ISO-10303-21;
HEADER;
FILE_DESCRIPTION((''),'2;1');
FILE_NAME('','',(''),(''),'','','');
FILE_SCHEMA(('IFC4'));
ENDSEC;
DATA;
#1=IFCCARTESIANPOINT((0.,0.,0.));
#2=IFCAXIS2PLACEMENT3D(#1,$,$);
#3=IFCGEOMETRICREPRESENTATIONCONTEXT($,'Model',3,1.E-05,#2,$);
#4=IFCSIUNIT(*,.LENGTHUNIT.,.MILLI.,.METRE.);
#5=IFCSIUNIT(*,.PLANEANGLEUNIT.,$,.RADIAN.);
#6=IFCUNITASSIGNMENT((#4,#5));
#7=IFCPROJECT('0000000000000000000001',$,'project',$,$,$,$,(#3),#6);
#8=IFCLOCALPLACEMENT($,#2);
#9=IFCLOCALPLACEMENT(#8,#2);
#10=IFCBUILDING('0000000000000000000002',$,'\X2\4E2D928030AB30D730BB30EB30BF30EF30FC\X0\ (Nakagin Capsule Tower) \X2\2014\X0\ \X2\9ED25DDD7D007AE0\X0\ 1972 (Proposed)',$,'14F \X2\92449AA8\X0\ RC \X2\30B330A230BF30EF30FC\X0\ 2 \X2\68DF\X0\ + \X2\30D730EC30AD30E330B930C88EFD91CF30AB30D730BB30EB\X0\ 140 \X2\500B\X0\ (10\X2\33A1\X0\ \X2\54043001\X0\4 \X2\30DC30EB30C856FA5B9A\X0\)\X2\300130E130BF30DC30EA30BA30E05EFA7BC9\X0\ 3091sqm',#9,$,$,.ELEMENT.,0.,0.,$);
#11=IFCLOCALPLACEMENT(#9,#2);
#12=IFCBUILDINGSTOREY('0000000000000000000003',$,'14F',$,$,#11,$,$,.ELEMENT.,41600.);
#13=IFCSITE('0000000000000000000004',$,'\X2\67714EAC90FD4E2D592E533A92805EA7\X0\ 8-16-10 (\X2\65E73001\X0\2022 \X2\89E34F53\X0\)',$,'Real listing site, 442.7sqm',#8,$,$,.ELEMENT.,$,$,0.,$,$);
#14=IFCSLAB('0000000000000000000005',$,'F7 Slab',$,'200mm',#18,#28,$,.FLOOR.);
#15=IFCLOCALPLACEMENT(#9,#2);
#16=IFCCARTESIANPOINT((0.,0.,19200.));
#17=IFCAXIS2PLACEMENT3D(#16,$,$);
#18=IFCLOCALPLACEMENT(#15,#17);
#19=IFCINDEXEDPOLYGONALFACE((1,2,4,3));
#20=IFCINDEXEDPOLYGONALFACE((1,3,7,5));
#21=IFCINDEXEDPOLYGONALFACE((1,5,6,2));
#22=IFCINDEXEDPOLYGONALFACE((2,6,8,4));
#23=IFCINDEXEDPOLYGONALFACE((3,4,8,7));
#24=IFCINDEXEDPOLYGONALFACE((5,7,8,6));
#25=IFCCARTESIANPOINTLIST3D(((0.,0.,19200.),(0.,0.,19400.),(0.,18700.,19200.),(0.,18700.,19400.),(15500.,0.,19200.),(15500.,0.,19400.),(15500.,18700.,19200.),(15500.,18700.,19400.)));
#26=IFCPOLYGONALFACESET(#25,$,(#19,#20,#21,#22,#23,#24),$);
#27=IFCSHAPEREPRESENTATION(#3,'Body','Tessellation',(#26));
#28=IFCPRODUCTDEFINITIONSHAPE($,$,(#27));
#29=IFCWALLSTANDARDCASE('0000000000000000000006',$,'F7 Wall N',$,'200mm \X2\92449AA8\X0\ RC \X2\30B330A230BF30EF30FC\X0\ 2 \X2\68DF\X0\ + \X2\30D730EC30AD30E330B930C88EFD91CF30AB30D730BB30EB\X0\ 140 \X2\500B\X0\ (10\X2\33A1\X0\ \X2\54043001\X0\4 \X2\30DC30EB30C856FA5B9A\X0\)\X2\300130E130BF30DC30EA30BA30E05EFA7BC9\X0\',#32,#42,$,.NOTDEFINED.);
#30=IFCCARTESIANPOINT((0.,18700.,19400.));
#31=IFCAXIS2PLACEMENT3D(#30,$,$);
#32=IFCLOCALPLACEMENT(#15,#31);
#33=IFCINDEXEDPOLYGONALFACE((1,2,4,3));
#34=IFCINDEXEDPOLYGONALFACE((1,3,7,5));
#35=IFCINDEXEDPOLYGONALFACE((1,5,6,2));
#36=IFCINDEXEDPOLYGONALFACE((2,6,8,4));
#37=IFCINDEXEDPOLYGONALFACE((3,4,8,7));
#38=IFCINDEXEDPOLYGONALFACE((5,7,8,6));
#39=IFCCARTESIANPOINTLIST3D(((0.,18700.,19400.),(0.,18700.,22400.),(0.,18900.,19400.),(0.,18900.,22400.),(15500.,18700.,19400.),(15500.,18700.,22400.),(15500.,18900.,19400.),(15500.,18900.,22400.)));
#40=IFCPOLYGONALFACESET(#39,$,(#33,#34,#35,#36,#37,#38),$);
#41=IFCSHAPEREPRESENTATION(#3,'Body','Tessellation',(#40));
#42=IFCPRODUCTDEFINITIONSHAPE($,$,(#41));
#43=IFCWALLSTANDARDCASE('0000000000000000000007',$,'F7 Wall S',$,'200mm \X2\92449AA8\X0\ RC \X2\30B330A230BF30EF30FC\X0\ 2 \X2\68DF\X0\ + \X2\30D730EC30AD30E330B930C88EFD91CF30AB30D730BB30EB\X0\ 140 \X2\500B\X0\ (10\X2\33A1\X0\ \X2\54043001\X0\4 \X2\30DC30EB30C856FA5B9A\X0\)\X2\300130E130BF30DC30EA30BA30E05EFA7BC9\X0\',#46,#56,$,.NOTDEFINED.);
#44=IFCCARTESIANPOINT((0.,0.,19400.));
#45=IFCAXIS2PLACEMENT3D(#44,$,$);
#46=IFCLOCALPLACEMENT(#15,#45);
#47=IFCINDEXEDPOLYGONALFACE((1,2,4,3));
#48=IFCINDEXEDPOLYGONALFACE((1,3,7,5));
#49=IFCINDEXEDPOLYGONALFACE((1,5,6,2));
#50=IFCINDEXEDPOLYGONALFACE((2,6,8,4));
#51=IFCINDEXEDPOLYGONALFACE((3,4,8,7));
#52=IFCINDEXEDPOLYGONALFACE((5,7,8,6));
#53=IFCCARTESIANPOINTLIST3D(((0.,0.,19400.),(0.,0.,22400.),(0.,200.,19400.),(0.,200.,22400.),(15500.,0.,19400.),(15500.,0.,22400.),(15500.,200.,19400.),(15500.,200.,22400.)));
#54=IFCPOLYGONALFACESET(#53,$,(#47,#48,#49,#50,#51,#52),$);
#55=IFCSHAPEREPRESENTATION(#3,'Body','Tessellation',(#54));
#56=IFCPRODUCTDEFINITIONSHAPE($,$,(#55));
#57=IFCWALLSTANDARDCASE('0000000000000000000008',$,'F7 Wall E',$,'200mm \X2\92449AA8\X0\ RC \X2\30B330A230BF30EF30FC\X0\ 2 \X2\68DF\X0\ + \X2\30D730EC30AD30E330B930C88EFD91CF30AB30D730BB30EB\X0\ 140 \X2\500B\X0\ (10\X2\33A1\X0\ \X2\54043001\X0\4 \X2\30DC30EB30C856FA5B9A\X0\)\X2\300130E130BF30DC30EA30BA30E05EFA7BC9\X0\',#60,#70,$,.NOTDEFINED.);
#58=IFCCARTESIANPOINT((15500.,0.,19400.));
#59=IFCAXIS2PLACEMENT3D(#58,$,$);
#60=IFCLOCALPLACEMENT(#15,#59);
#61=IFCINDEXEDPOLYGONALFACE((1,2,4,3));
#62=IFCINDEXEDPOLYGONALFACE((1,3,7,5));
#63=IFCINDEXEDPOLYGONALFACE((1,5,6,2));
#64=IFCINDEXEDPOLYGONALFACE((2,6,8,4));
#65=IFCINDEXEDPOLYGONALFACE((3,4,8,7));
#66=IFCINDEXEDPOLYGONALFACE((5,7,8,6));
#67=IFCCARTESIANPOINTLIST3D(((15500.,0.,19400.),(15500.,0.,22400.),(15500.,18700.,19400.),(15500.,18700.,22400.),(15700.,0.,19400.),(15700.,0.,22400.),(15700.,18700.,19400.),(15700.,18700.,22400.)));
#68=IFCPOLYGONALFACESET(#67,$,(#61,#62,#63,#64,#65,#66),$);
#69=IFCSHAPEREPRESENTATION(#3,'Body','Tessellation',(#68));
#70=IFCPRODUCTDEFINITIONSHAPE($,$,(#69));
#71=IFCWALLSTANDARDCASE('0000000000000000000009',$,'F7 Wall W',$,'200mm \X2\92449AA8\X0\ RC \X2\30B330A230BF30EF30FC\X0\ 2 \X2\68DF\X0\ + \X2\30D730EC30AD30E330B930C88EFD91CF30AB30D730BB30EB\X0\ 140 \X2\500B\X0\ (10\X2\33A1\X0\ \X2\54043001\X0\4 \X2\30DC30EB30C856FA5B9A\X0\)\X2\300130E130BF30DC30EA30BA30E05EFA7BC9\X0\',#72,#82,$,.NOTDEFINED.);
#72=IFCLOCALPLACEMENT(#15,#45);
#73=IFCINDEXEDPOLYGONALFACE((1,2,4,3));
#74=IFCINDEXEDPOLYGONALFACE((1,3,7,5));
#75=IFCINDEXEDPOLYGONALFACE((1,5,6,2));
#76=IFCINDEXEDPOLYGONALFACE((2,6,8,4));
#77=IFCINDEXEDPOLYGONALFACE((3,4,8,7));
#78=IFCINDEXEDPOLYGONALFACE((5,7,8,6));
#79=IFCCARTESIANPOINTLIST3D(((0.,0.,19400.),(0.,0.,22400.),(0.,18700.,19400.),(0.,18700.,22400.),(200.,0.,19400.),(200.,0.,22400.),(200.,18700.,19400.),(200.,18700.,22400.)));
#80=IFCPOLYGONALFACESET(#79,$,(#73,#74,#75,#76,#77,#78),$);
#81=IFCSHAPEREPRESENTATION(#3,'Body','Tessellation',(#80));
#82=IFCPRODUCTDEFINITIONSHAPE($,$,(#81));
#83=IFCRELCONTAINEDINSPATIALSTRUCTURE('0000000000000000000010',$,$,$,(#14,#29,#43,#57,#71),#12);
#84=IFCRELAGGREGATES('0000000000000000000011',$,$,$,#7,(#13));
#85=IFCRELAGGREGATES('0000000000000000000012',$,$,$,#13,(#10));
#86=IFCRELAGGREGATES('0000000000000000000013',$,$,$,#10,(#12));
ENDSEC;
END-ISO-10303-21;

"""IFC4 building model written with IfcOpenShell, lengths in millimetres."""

from ifc_helpers import new_model, si_unit, frame, frame_2d, origin, place, context, project, spatial, rectangle, extrude, element, save


model = new_model("IFC4")

# Units and contexts
model_context = context("Model", 3, precision=1e-05, world=origin())
ifc_project = project(units=[si_unit("LENGTHUNIT", "METRE", prefix="MILLI"), si_unit("PLANEANGLEUNIT", "RADIAN")], contexts=[model_context])

# Site, building, storey
site_placement = place(None, origin())
site = spatial("IfcSite", under=ifc_project, at=site_placement, Name="東京都中央区銀座 8-16-10 (旧、2022 解体)", ObjectType="Real listing site, 442.7sqm", CompositionType="ELEMENT", RefElevation=0.0)
building_placement = place(site_placement, origin())
building = spatial("IfcBuilding", under=site, at=building_placement, Name="中銀カプセルタワー (Nakagin Capsule Tower) — 黒川紀章 1972 (Proposed)", ObjectType="14F 鉄骨 RC コアタワー 2 棟 + プレキャスト軽量カプセル 140 個 (10㎡ 各、4 ボルト固定)、メタボリズム建築 3091sqm", CompositionType="ELEMENT", ElevationOfRefHeight=0.0, ElevationOfTerrain=0.0)
storey_placement = place(building_placement, origin())
storey = spatial("IfcBuildingStorey", under=building, at=storey_placement, Name="14F", CompositionType="ELEMENT", Elevation=41600.0)

# Slab
placement = place(building_placement, origin())
slab_placement = place(placement, frame((0.0, 0.0, 19200.0)))
element("IfcSlab", 1, at=slab_placement, inside=storey, Name="F7 Slab", ObjectType="200mm", PredefinedType="FLOOR", context=model_context, shape_type="SweptSolid", body=[
    extrude(rectangle(XDim=15500.0, YDim=18700.0, at=frame_2d((7750.0, 9350.0))), frame((0.0, 0.0, 19200.0)), (0.0, 0.0, 1.0), 200.0),
])

# Walls
wall_1_placement = place(placement, frame((0.0, 18700.0, 19400.0)))
element("IfcWallStandardCase", 2, at=wall_1_placement, inside=storey, Name="F7 Wall N", ObjectType="200mm 鉄骨 RC コアタワー 2 棟 + プレキャスト軽量カプセル 140 個 (10㎡ 各、4 ボルト固定)、メタボリズム建築", PredefinedType="NOTDEFINED", context=model_context, shape_type="SweptSolid", body=[
    extrude(rectangle(XDim=15500.0, YDim=200.0, at=frame_2d((7750.0, 100.0))), frame((0.0, 18700.0, 19400.0)), (0.0, 0.0, 1.0), 3000.0),
])
wall_2_placement = place(placement, frame((0.0, 0.0, 19400.0)))
element("IfcWallStandardCase", 3, at=wall_2_placement, inside=storey, Name="F7 Wall S", ObjectType="200mm 鉄骨 RC コアタワー 2 棟 + プレキャスト軽量カプセル 140 個 (10㎡ 各、4 ボルト固定)、メタボリズム建築", PredefinedType="NOTDEFINED", context=model_context, shape_type="SweptSolid", body=[
    extrude(rectangle(XDim=15500.0, YDim=200.0, at=frame_2d((7750.0, 100.0))), frame((0.0, 0.0, 19400.0)), (0.0, 0.0, 1.0), 3000.0),
])
wall_3_placement = place(placement, frame((15500.0, 0.0, 19400.0)))
element("IfcWallStandardCase", 4, at=wall_3_placement, inside=storey, Name="F7 Wall E", ObjectType="200mm 鉄骨 RC コアタワー 2 棟 + プレキャスト軽量カプセル 140 個 (10㎡ 各、4 ボルト固定)、メタボリズム建築", PredefinedType="NOTDEFINED", context=model_context, shape_type="SweptSolid", body=[
    extrude(rectangle(XDim=200.0, YDim=18700.0, at=frame_2d((100.0, 9350.0))), frame((15500.0, 0.0, 19400.0)), (0.0, 0.0, 1.0), 3000.0),
])
wall_4_placement = place(placement, frame((0.0, 0.0, 19400.0)))
element("IfcWallStandardCase", 5, at=wall_4_placement, inside=storey, Name="F7 Wall W", ObjectType="200mm 鉄骨 RC コアタワー 2 棟 + プレキャスト軽量カプセル 140 個 (10㎡ 各、4 ボルト固定)、メタボリズム建築", PredefinedType="NOTDEFINED", context=model_context, shape_type="SweptSolid", body=[
    extrude(rectangle(XDim=200.0, YDim=18700.0, at=frame_2d((100.0, 9350.0))), frame((0.0, 0.0, 19400.0)), (0.0, 0.0, 1.0), 3000.0),
])

save(model, "model.ifc")
